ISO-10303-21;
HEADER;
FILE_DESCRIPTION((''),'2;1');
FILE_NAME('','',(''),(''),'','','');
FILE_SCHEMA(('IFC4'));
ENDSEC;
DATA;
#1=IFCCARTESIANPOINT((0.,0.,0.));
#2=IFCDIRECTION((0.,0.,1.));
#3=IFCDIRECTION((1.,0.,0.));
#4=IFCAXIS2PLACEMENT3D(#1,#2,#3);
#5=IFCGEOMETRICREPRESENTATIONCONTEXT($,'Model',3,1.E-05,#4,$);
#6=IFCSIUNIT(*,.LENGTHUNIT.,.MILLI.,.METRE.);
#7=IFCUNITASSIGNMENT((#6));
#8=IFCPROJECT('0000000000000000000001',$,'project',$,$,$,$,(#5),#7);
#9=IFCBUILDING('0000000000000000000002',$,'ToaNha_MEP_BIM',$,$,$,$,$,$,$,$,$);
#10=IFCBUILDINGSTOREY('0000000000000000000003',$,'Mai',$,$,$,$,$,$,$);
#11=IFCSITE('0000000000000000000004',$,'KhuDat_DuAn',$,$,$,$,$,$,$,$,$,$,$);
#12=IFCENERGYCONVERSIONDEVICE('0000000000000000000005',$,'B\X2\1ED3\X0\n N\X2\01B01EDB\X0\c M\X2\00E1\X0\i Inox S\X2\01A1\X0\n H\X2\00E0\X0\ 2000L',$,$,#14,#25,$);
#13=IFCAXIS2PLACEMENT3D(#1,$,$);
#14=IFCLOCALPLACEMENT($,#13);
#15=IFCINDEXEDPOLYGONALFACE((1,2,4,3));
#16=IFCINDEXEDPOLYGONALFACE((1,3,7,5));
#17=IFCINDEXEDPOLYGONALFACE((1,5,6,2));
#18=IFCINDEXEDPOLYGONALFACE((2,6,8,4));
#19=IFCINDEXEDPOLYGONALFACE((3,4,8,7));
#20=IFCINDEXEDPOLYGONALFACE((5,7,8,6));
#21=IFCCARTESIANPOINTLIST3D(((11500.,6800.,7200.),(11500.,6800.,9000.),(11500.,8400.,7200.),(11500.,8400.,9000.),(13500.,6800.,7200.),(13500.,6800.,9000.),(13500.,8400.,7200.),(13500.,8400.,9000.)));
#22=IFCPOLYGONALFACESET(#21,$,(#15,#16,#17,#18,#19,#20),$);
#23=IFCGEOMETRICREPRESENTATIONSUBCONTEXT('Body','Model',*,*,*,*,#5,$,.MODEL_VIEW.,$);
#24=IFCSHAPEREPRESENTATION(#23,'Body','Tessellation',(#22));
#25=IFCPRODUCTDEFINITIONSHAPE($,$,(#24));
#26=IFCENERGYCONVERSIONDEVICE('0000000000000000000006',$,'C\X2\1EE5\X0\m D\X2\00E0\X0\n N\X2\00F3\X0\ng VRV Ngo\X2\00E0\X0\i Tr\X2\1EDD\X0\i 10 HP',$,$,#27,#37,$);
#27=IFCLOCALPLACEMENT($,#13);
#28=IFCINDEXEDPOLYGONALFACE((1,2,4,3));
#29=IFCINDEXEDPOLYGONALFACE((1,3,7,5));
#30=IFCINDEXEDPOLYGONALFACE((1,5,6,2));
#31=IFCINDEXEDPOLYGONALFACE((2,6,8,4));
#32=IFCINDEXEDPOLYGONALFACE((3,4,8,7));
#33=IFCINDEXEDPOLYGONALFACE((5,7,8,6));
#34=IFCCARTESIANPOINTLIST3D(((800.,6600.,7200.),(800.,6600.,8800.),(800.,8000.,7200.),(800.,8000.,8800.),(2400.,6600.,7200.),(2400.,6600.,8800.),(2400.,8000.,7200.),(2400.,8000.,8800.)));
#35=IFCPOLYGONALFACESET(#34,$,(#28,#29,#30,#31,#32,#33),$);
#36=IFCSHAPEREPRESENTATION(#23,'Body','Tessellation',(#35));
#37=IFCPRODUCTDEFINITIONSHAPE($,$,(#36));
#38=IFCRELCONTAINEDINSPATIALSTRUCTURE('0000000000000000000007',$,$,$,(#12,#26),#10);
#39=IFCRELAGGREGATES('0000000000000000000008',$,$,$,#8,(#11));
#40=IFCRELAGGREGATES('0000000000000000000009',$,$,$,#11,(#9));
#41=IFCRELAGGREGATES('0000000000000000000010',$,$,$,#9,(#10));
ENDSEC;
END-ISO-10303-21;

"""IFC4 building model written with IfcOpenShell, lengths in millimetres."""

from ifc_helpers import new_model, si_unit, frame, origin_with_axes, context, subcontext, project, spatial, polyline, outline, extrude, element, save


model = new_model("IFC4")

# Units and contexts
model_context = context("Model", 3, precision=1e-05, world=origin_with_axes())
body_context = subcontext(model_context, "Body", "Model", "MODEL_VIEW")
ifc_project = project(units=[si_unit("LENGTHUNIT", "METRE", prefix="MILLI")], contexts=[model_context])

# Site, building, storey
site = spatial("IfcSite", under=ifc_project, Name="KhuDat_DuAn")
building = spatial("IfcBuilding", under=site, Name="ToaNha_MEP_BIM")
storey = spatial("IfcBuildingStorey", under=building, Name="Mai")

# Energy conversion devices
element("IfcEnergyConversionDevice", 1, inside=storey, Name="Bồn Nước Mái Inox Sơn Hà 2000L", context=body_context, shape_type="SweptSolid", body=[
    extrude(outline(polyline([(11500.0, 6800.0), (13500.0, 6800.0), (13500.0, 8400.0), (11500.0, 8400.0), (11500.0, 6800.0)])), frame((0.0, 0.0, 7200.0), z_axis=(0.0, 0.0, 1.0), x_axis=(1.0, 0.0, 0.0)), (0.0, 0.0, 1.0), 1800.0),
])
element("IfcEnergyConversionDevice", 2, inside=storey, Name="Cụm Dàn Nóng VRV Ngoài Trời 10 HP", context=body_context, shape_type="SweptSolid", body=[
    extrude(outline(polyline([(800.0, 6600.0), (2400.0, 6600.0), (2400.0, 8000.0), (800.0, 8000.0), (800.0, 6600.0)])), frame((0.0, 0.0, 7200.0), z_axis=(0.0, 0.0, 1.0), x_axis=(1.0, 0.0, 0.0)), (0.0, 0.0, 1.0), 1600.0),
])

save(model, "model.ifc")
